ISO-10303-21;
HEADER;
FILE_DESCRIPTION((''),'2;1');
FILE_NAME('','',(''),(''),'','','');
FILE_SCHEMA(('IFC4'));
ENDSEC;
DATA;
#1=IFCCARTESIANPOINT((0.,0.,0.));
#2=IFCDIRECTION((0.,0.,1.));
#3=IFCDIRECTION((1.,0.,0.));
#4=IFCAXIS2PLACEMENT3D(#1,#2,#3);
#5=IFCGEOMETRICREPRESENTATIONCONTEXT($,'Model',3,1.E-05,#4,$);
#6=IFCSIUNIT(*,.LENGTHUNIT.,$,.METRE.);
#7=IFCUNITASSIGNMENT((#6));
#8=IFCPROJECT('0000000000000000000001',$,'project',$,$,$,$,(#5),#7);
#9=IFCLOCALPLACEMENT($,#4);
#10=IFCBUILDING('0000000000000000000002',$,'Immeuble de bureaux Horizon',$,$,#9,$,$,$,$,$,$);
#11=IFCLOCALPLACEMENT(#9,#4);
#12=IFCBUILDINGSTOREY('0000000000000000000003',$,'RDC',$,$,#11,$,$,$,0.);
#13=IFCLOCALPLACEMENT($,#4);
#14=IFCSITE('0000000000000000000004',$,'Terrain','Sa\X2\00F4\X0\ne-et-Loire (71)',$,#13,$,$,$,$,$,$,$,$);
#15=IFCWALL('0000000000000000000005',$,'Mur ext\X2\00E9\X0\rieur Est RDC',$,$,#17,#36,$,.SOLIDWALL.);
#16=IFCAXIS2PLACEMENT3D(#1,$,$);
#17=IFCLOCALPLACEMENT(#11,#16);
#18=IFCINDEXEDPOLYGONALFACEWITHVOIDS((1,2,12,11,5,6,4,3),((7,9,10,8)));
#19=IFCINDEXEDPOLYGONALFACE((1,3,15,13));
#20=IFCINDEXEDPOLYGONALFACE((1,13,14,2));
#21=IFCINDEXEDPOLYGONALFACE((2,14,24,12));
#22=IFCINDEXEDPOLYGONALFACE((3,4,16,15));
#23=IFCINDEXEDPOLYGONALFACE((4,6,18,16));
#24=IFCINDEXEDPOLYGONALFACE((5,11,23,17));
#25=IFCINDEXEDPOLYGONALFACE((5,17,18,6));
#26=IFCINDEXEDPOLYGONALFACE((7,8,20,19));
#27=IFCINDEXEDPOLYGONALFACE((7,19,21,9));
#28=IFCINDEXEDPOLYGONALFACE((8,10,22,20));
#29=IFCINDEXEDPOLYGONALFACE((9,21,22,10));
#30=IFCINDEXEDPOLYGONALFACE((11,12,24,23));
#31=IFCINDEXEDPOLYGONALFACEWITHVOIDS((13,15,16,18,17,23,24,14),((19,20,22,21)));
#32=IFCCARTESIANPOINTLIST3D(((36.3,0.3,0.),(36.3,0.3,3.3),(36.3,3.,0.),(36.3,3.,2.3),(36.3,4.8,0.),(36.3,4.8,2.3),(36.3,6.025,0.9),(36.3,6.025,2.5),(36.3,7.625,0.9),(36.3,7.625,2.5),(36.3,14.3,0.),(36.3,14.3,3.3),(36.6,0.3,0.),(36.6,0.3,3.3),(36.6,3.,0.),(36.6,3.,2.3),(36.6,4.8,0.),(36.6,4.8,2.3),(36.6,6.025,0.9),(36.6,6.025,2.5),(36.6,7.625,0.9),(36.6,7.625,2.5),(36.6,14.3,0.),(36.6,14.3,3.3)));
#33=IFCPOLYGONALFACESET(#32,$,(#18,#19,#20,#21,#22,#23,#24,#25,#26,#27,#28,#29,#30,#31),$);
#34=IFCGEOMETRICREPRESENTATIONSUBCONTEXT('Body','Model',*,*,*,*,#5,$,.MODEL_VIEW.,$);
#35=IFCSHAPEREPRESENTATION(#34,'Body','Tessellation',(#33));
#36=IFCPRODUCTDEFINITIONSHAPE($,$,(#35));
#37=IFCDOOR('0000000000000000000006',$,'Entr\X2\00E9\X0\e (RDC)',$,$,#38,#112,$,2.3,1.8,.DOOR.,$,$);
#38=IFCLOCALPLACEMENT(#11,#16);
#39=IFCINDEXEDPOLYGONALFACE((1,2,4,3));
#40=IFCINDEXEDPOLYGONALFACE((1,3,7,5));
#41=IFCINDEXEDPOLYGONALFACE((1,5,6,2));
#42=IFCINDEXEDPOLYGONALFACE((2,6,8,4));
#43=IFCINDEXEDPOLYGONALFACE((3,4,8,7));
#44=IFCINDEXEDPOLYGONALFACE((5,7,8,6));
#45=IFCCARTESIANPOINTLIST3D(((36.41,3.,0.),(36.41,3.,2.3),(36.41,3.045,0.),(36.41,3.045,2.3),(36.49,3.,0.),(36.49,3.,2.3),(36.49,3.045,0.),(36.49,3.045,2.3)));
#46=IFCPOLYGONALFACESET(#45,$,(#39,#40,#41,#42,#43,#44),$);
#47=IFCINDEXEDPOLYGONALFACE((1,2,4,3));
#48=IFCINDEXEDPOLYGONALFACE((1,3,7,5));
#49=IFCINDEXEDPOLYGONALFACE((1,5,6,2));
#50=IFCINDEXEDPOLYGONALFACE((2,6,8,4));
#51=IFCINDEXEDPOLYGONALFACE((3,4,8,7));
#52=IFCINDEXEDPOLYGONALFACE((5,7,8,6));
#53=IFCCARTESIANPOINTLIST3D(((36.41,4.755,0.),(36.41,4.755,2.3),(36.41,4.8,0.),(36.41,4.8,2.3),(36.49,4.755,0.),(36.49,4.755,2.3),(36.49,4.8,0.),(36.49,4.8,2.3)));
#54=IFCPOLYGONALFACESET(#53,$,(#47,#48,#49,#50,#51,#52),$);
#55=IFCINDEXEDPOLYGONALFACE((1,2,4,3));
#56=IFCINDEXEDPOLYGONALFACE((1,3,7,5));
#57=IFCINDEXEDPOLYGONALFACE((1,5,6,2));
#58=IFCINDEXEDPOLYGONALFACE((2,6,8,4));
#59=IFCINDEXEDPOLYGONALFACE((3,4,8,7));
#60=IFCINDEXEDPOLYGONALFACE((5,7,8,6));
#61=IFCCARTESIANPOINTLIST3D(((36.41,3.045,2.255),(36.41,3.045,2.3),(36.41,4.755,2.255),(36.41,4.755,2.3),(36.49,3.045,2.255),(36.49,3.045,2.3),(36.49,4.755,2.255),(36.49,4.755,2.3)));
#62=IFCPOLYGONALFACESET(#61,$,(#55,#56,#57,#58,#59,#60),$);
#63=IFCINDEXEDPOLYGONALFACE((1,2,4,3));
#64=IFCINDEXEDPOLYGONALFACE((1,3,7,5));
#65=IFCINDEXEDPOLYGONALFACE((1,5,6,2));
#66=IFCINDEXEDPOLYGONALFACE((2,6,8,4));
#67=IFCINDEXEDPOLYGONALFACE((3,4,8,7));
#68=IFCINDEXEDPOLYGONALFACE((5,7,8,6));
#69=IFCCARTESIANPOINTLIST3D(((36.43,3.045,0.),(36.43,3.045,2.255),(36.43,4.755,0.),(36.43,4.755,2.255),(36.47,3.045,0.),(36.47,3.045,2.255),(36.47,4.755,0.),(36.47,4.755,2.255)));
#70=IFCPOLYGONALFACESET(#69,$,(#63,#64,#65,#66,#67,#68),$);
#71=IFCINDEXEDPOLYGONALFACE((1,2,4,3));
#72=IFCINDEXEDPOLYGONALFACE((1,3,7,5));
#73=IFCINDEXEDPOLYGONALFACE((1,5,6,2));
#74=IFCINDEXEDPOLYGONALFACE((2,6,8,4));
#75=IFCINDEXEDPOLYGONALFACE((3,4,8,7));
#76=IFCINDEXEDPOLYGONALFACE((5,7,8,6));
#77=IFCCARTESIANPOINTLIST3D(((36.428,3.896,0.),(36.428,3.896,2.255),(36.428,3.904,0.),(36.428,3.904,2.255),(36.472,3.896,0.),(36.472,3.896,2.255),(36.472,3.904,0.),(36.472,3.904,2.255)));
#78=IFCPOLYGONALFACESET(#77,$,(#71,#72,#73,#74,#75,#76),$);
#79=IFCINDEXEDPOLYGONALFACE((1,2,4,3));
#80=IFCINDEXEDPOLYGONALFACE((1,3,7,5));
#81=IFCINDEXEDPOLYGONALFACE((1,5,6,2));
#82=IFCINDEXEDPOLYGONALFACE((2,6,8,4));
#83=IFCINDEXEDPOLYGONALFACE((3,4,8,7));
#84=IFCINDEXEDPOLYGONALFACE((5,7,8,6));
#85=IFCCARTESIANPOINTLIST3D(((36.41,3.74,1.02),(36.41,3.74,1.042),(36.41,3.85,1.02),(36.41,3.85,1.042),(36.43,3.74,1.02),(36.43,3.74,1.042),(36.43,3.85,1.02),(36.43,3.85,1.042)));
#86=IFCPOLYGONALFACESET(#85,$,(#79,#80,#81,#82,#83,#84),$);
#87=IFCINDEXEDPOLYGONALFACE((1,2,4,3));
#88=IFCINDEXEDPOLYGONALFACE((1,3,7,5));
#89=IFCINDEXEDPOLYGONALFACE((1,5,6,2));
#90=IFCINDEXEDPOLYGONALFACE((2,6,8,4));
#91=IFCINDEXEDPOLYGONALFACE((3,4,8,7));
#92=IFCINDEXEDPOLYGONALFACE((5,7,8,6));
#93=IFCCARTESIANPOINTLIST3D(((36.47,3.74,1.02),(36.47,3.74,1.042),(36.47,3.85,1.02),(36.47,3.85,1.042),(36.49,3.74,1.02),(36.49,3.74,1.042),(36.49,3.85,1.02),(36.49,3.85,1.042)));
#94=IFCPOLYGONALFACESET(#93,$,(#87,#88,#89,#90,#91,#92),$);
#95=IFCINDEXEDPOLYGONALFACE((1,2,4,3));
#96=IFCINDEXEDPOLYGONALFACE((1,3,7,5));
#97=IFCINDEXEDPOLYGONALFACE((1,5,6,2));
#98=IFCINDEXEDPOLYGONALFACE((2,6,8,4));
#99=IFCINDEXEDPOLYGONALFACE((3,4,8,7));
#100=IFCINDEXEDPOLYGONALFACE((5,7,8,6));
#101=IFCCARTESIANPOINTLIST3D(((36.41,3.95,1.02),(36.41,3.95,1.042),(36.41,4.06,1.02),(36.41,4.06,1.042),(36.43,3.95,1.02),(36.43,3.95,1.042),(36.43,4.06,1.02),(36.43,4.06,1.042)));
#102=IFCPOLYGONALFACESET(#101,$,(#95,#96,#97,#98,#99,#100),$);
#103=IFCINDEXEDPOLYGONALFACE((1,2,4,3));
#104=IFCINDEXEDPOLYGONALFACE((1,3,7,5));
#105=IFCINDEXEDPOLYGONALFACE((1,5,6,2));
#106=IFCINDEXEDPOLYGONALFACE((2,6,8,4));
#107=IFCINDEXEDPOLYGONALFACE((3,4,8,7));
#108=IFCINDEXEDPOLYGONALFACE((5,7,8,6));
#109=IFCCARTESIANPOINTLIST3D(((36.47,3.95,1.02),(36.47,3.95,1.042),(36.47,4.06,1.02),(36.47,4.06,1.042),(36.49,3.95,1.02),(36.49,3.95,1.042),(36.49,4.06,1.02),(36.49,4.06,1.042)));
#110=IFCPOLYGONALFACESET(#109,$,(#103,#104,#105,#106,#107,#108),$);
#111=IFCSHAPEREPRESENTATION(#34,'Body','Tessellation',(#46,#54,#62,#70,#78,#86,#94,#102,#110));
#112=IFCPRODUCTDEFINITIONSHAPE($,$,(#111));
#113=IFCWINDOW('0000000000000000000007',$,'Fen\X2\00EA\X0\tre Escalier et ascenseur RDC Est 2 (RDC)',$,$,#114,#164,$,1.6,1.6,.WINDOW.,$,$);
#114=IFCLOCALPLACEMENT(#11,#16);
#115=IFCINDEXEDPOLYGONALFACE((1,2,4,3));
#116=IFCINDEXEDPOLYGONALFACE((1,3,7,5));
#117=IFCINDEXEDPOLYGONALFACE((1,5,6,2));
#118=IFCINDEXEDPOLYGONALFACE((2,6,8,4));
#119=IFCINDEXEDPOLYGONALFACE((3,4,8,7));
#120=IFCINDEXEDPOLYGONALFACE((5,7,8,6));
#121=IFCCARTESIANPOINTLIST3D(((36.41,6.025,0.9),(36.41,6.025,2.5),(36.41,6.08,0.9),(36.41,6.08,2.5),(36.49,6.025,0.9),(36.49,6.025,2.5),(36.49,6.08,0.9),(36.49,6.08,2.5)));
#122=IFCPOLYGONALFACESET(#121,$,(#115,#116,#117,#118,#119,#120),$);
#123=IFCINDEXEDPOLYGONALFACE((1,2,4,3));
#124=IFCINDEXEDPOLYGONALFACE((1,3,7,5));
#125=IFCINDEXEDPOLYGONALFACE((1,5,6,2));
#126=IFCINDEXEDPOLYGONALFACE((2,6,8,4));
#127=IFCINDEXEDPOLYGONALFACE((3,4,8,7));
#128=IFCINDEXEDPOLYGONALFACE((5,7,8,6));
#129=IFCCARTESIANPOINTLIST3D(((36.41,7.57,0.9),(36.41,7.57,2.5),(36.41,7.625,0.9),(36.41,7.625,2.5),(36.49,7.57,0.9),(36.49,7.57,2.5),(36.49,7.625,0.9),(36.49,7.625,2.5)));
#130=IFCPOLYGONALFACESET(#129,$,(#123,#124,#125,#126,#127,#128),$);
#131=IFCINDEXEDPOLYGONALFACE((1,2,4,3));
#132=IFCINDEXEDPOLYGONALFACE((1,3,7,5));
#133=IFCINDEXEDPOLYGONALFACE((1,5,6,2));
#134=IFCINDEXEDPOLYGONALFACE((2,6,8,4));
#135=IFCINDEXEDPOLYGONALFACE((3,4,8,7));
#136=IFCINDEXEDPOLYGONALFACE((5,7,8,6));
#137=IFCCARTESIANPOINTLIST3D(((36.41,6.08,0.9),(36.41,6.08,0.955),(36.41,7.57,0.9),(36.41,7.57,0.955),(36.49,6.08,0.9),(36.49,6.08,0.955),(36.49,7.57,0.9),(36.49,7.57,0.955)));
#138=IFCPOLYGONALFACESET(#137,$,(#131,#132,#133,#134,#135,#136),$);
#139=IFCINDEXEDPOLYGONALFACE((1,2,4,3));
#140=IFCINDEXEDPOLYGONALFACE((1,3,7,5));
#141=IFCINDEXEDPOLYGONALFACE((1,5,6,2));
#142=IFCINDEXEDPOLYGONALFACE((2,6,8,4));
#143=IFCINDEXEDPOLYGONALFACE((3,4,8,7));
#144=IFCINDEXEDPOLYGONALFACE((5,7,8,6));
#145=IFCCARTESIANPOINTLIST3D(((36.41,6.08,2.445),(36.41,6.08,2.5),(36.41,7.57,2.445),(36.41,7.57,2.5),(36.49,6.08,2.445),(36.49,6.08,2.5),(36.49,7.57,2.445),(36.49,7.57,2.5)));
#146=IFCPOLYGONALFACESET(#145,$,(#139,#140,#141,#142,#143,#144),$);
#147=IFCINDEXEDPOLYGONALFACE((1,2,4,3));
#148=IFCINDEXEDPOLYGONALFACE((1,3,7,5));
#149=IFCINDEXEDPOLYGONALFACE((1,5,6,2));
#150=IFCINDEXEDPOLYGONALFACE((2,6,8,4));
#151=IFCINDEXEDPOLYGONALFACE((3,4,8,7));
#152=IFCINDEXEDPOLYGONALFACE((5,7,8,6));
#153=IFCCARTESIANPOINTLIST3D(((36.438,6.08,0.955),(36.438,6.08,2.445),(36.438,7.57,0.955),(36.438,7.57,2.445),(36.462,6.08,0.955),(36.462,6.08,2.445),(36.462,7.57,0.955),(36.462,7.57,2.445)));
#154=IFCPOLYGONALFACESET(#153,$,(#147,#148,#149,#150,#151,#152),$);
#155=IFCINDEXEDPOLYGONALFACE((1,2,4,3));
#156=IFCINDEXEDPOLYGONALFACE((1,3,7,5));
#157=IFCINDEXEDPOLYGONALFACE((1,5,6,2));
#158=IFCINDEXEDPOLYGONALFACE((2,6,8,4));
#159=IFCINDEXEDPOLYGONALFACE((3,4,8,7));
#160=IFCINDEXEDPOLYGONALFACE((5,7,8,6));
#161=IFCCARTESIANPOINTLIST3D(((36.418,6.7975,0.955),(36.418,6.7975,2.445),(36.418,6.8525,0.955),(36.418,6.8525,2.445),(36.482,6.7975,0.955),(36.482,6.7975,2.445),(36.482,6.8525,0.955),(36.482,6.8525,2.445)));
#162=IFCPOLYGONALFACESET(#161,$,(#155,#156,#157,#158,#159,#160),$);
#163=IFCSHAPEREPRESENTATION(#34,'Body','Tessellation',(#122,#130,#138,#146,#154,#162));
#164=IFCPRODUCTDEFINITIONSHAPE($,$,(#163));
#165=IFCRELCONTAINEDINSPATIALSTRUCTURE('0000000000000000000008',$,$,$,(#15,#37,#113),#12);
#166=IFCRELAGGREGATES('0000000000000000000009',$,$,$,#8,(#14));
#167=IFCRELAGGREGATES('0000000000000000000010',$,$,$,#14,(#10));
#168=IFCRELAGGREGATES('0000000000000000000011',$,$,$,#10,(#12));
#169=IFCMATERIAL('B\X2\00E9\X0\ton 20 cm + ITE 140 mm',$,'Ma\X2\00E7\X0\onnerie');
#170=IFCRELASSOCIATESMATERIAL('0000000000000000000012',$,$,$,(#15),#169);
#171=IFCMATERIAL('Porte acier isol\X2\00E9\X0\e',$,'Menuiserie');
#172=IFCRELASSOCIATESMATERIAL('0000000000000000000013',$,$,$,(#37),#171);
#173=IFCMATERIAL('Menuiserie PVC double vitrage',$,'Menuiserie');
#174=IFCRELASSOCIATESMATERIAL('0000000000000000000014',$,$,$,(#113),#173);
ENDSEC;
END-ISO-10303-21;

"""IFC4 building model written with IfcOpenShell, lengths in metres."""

from ifc_helpers import new_model, si_unit, frame, frame_2d, origin_with_axes, place, context, subcontext, project, spatial, rectangle, extrude, material, element, fill, save


model = new_model("IFC4")

# Units and contexts
model_context = context("Model", 3, precision=1e-05, world=origin_with_axes())
body_context = subcontext(model_context, "Body", "Model", "MODEL_VIEW")
ifc_project = project(units=[si_unit("LENGTHUNIT", "METRE")], contexts=[model_context])

# Site, building, storey
site_placement = place(None, origin_with_axes())
site = spatial("IfcSite", under=ifc_project, at=site_placement, Name="Terrain", Description="Saône-et-Loire (71)")
building_placement = place(None, origin_with_axes())
building = spatial("IfcBuilding", under=site, at=building_placement, Name="Immeuble de bureaux Horizon")
storey_placement = place(building_placement, origin_with_axes())
storey = spatial("IfcBuildingStorey", under=building, at=storey_placement, Name="RDC", Elevation=0.0)

# Wall, openings, door, window
ifc_material_1 = material(Name="Béton 20 cm + ITE 140 mm", Category="Maçonnerie")
wall_1_placement = place(storey_placement, frame((36.3, 0.3, 0.0), z_axis=(0.0, 0.0, 1.0), x_axis=(1.0, 0.0, 0.0)))
wall_1 = element("IfcWall", 1, at=wall_1_placement, inside=storey, material=ifc_material_1, Name="Mur extérieur Est RDC", PredefinedType="SOLIDWALL", context=body_context, shape_type="SweptSolid", body=[
    extrude(rectangle(XDim=0.3, YDim=14.0, at=frame_2d((0.15, 7.0))), origin_with_axes(), (0.0, 0.0, 1.0), 3.3),
])
opening_1_placement = place(storey_placement, frame((36.25, 3.0, 0.0), z_axis=(0.0, 0.0, 1.0), x_axis=(1.0, 0.0, 0.0)))
opening_1 = element("IfcOpeningElement", 2, at=opening_1_placement, cuts=wall_1, context=body_context, shape_type="SweptSolid", body=[
    extrude(rectangle(XDim=0.4, YDim=1.8, at=frame_2d((0.2, 0.9))), origin_with_axes(), (0.0, 0.0, 1.0), 2.3),
])
opening_2_placement = place(storey_placement, frame((36.25, 6.025, 0.9), z_axis=(0.0, 0.0, 1.0), x_axis=(1.0, 0.0, 0.0)))
opening_2 = element("IfcOpeningElement", 3, at=opening_2_placement, cuts=wall_1, context=body_context, shape_type="SweptSolid", body=[
    extrude(rectangle(XDim=0.4, YDim=1.6, at=frame_2d((0.2, 0.8))), origin_with_axes(), (0.0, 0.0, 1.0), 1.6),
])
ifc_material_2 = material(Name="Porte acier isolée", Category="Menuiserie")
door_1_placement = place(storey_placement, frame((36.41, 3.0, 0.0), z_axis=(0.0, 0.0, 1.0), x_axis=(1.0, 0.0, 0.0)))
door_1 = element("IfcDoor", 4, at=door_1_placement, inside=storey, material=ifc_material_2, Name="Entrée (RDC)", OverallHeight=2.3, OverallWidth=1.8, PredefinedType="DOOR", context=body_context, shape_type="SweptSolid", body=[
    extrude(rectangle(XDim=0.08, YDim=0.045, at=frame_2d((0.04, 0.0225))), origin_with_axes(), (0.0, 0.0, 1.0), 2.3),
    extrude(rectangle(XDim=0.08, YDim=0.045, at=frame_2d((0.04, 0.0225))), frame((0.0, 1.755, 0.0), z_axis=(0.0, 0.0, 1.0), x_axis=(1.0, 0.0, 0.0)), (0.0, 0.0, 1.0), 2.3),
    extrude(rectangle(XDim=0.08, YDim=1.71, at=frame_2d((0.04, 0.855))), frame((0.0, 0.045, 2.255), z_axis=(0.0, 0.0, 1.0), x_axis=(1.0, 0.0, 0.0)), (0.0, 0.0, 1.0), 0.045),
    extrude(rectangle(XDim=0.04, YDim=1.71, at=frame_2d((0.02, 0.855))), frame((0.02, 0.045, 0.0), z_axis=(0.0, 0.0, 1.0), x_axis=(1.0, 0.0, 0.0)), (0.0, 0.0, 1.0), 2.255),
    extrude(rectangle(XDim=0.044, YDim=0.008, at=frame_2d((0.022, 0.004))), frame((0.018, 0.896, 0.0), z_axis=(0.0, 0.0, 1.0), x_axis=(1.0, 0.0, 0.0)), (0.0, 0.0, 1.0), 2.255),
    extrude(rectangle(XDim=0.02, YDim=0.11, at=frame_2d((0.01, 0.055))), frame((0.0, 0.74, 1.02), z_axis=(0.0, 0.0, 1.0), x_axis=(1.0, 0.0, 0.0)), (0.0, 0.0, 1.0), 0.022),
    extrude(rectangle(XDim=0.02, YDim=0.11, at=frame_2d((0.01, 0.055))), frame((0.06, 0.74, 1.02), z_axis=(0.0, 0.0, 1.0), x_axis=(1.0, 0.0, 0.0)), (0.0, 0.0, 1.0), 0.022),
    extrude(rectangle(XDim=0.02, YDim=0.11, at=frame_2d((0.01, 0.055))), frame((0.0, 0.95, 1.02), z_axis=(0.0, 0.0, 1.0), x_axis=(1.0, 0.0, 0.0)), (0.0, 0.0, 1.0), 0.022),
    extrude(rectangle(XDim=0.02, YDim=0.11, at=frame_2d((0.01, 0.055))), frame((0.06, 0.95, 1.02), z_axis=(0.0, 0.0, 1.0), x_axis=(1.0, 0.0, 0.0)), (0.0, 0.0, 1.0), 0.022),
])
fill(opening_1, door_1)
ifc_material_3 = material(Name="Menuiserie PVC double vitrage", Category="Menuiserie")
window_placement = place(storey_placement, frame((36.41, 6.025, 0.9), z_axis=(0.0, 0.0, 1.0), x_axis=(1.0, 0.0, 0.0)))
window = element("IfcWindow", 5, at=window_placement, inside=storey, material=ifc_material_3, Name="Fenêtre Escalier et ascenseur RDC Est 2 (RDC)", OverallHeight=1.6, OverallWidth=1.6, PredefinedType="WINDOW", context=body_context, shape_type="SweptSolid", body=[
    extrude(rectangle(XDim=0.08, YDim=0.055, at=frame_2d((0.04, 0.0275))), origin_with_axes(), (0.0, 0.0, 1.0), 1.6),
    extrude(rectangle(XDim=0.08, YDim=0.055, at=frame_2d((0.04, 0.0275))), frame((0.0, 1.545, 0.0), z_axis=(0.0, 0.0, 1.0), x_axis=(1.0, 0.0, 0.0)), (0.0, 0.0, 1.0), 1.6),
    extrude(rectangle(XDim=0.08, YDim=1.49, at=frame_2d((0.04, 0.745))), frame((0.0, 0.055, 0.0), z_axis=(0.0, 0.0, 1.0), x_axis=(1.0, 0.0, 0.0)), (0.0, 0.0, 1.0), 0.055),
    extrude(rectangle(XDim=0.08, YDim=1.49, at=frame_2d((0.04, 0.745))), frame((0.0, 0.055, 1.545), z_axis=(0.0, 0.0, 1.0), x_axis=(1.0, 0.0, 0.0)), (0.0, 0.0, 1.0), 0.055),
    extrude(rectangle(XDim=0.024, YDim=1.49, at=frame_2d((0.012, 0.745))), frame((0.028, 0.055, 0.055), z_axis=(0.0, 0.0, 1.0), x_axis=(1.0, 0.0, 0.0)), (0.0, 0.0, 1.0), 1.49),
    extrude(rectangle(XDim=0.064, YDim=0.055, at=frame_2d((0.032, 0.0275))), frame((0.008, 0.7725, 0.055), z_axis=(0.0, 0.0, 1.0), x_axis=(1.0, 0.0, 0.0)), (0.0, 0.0, 1.0), 1.49),
])
fill(opening_2, window)

save(model, "model.ifc")
